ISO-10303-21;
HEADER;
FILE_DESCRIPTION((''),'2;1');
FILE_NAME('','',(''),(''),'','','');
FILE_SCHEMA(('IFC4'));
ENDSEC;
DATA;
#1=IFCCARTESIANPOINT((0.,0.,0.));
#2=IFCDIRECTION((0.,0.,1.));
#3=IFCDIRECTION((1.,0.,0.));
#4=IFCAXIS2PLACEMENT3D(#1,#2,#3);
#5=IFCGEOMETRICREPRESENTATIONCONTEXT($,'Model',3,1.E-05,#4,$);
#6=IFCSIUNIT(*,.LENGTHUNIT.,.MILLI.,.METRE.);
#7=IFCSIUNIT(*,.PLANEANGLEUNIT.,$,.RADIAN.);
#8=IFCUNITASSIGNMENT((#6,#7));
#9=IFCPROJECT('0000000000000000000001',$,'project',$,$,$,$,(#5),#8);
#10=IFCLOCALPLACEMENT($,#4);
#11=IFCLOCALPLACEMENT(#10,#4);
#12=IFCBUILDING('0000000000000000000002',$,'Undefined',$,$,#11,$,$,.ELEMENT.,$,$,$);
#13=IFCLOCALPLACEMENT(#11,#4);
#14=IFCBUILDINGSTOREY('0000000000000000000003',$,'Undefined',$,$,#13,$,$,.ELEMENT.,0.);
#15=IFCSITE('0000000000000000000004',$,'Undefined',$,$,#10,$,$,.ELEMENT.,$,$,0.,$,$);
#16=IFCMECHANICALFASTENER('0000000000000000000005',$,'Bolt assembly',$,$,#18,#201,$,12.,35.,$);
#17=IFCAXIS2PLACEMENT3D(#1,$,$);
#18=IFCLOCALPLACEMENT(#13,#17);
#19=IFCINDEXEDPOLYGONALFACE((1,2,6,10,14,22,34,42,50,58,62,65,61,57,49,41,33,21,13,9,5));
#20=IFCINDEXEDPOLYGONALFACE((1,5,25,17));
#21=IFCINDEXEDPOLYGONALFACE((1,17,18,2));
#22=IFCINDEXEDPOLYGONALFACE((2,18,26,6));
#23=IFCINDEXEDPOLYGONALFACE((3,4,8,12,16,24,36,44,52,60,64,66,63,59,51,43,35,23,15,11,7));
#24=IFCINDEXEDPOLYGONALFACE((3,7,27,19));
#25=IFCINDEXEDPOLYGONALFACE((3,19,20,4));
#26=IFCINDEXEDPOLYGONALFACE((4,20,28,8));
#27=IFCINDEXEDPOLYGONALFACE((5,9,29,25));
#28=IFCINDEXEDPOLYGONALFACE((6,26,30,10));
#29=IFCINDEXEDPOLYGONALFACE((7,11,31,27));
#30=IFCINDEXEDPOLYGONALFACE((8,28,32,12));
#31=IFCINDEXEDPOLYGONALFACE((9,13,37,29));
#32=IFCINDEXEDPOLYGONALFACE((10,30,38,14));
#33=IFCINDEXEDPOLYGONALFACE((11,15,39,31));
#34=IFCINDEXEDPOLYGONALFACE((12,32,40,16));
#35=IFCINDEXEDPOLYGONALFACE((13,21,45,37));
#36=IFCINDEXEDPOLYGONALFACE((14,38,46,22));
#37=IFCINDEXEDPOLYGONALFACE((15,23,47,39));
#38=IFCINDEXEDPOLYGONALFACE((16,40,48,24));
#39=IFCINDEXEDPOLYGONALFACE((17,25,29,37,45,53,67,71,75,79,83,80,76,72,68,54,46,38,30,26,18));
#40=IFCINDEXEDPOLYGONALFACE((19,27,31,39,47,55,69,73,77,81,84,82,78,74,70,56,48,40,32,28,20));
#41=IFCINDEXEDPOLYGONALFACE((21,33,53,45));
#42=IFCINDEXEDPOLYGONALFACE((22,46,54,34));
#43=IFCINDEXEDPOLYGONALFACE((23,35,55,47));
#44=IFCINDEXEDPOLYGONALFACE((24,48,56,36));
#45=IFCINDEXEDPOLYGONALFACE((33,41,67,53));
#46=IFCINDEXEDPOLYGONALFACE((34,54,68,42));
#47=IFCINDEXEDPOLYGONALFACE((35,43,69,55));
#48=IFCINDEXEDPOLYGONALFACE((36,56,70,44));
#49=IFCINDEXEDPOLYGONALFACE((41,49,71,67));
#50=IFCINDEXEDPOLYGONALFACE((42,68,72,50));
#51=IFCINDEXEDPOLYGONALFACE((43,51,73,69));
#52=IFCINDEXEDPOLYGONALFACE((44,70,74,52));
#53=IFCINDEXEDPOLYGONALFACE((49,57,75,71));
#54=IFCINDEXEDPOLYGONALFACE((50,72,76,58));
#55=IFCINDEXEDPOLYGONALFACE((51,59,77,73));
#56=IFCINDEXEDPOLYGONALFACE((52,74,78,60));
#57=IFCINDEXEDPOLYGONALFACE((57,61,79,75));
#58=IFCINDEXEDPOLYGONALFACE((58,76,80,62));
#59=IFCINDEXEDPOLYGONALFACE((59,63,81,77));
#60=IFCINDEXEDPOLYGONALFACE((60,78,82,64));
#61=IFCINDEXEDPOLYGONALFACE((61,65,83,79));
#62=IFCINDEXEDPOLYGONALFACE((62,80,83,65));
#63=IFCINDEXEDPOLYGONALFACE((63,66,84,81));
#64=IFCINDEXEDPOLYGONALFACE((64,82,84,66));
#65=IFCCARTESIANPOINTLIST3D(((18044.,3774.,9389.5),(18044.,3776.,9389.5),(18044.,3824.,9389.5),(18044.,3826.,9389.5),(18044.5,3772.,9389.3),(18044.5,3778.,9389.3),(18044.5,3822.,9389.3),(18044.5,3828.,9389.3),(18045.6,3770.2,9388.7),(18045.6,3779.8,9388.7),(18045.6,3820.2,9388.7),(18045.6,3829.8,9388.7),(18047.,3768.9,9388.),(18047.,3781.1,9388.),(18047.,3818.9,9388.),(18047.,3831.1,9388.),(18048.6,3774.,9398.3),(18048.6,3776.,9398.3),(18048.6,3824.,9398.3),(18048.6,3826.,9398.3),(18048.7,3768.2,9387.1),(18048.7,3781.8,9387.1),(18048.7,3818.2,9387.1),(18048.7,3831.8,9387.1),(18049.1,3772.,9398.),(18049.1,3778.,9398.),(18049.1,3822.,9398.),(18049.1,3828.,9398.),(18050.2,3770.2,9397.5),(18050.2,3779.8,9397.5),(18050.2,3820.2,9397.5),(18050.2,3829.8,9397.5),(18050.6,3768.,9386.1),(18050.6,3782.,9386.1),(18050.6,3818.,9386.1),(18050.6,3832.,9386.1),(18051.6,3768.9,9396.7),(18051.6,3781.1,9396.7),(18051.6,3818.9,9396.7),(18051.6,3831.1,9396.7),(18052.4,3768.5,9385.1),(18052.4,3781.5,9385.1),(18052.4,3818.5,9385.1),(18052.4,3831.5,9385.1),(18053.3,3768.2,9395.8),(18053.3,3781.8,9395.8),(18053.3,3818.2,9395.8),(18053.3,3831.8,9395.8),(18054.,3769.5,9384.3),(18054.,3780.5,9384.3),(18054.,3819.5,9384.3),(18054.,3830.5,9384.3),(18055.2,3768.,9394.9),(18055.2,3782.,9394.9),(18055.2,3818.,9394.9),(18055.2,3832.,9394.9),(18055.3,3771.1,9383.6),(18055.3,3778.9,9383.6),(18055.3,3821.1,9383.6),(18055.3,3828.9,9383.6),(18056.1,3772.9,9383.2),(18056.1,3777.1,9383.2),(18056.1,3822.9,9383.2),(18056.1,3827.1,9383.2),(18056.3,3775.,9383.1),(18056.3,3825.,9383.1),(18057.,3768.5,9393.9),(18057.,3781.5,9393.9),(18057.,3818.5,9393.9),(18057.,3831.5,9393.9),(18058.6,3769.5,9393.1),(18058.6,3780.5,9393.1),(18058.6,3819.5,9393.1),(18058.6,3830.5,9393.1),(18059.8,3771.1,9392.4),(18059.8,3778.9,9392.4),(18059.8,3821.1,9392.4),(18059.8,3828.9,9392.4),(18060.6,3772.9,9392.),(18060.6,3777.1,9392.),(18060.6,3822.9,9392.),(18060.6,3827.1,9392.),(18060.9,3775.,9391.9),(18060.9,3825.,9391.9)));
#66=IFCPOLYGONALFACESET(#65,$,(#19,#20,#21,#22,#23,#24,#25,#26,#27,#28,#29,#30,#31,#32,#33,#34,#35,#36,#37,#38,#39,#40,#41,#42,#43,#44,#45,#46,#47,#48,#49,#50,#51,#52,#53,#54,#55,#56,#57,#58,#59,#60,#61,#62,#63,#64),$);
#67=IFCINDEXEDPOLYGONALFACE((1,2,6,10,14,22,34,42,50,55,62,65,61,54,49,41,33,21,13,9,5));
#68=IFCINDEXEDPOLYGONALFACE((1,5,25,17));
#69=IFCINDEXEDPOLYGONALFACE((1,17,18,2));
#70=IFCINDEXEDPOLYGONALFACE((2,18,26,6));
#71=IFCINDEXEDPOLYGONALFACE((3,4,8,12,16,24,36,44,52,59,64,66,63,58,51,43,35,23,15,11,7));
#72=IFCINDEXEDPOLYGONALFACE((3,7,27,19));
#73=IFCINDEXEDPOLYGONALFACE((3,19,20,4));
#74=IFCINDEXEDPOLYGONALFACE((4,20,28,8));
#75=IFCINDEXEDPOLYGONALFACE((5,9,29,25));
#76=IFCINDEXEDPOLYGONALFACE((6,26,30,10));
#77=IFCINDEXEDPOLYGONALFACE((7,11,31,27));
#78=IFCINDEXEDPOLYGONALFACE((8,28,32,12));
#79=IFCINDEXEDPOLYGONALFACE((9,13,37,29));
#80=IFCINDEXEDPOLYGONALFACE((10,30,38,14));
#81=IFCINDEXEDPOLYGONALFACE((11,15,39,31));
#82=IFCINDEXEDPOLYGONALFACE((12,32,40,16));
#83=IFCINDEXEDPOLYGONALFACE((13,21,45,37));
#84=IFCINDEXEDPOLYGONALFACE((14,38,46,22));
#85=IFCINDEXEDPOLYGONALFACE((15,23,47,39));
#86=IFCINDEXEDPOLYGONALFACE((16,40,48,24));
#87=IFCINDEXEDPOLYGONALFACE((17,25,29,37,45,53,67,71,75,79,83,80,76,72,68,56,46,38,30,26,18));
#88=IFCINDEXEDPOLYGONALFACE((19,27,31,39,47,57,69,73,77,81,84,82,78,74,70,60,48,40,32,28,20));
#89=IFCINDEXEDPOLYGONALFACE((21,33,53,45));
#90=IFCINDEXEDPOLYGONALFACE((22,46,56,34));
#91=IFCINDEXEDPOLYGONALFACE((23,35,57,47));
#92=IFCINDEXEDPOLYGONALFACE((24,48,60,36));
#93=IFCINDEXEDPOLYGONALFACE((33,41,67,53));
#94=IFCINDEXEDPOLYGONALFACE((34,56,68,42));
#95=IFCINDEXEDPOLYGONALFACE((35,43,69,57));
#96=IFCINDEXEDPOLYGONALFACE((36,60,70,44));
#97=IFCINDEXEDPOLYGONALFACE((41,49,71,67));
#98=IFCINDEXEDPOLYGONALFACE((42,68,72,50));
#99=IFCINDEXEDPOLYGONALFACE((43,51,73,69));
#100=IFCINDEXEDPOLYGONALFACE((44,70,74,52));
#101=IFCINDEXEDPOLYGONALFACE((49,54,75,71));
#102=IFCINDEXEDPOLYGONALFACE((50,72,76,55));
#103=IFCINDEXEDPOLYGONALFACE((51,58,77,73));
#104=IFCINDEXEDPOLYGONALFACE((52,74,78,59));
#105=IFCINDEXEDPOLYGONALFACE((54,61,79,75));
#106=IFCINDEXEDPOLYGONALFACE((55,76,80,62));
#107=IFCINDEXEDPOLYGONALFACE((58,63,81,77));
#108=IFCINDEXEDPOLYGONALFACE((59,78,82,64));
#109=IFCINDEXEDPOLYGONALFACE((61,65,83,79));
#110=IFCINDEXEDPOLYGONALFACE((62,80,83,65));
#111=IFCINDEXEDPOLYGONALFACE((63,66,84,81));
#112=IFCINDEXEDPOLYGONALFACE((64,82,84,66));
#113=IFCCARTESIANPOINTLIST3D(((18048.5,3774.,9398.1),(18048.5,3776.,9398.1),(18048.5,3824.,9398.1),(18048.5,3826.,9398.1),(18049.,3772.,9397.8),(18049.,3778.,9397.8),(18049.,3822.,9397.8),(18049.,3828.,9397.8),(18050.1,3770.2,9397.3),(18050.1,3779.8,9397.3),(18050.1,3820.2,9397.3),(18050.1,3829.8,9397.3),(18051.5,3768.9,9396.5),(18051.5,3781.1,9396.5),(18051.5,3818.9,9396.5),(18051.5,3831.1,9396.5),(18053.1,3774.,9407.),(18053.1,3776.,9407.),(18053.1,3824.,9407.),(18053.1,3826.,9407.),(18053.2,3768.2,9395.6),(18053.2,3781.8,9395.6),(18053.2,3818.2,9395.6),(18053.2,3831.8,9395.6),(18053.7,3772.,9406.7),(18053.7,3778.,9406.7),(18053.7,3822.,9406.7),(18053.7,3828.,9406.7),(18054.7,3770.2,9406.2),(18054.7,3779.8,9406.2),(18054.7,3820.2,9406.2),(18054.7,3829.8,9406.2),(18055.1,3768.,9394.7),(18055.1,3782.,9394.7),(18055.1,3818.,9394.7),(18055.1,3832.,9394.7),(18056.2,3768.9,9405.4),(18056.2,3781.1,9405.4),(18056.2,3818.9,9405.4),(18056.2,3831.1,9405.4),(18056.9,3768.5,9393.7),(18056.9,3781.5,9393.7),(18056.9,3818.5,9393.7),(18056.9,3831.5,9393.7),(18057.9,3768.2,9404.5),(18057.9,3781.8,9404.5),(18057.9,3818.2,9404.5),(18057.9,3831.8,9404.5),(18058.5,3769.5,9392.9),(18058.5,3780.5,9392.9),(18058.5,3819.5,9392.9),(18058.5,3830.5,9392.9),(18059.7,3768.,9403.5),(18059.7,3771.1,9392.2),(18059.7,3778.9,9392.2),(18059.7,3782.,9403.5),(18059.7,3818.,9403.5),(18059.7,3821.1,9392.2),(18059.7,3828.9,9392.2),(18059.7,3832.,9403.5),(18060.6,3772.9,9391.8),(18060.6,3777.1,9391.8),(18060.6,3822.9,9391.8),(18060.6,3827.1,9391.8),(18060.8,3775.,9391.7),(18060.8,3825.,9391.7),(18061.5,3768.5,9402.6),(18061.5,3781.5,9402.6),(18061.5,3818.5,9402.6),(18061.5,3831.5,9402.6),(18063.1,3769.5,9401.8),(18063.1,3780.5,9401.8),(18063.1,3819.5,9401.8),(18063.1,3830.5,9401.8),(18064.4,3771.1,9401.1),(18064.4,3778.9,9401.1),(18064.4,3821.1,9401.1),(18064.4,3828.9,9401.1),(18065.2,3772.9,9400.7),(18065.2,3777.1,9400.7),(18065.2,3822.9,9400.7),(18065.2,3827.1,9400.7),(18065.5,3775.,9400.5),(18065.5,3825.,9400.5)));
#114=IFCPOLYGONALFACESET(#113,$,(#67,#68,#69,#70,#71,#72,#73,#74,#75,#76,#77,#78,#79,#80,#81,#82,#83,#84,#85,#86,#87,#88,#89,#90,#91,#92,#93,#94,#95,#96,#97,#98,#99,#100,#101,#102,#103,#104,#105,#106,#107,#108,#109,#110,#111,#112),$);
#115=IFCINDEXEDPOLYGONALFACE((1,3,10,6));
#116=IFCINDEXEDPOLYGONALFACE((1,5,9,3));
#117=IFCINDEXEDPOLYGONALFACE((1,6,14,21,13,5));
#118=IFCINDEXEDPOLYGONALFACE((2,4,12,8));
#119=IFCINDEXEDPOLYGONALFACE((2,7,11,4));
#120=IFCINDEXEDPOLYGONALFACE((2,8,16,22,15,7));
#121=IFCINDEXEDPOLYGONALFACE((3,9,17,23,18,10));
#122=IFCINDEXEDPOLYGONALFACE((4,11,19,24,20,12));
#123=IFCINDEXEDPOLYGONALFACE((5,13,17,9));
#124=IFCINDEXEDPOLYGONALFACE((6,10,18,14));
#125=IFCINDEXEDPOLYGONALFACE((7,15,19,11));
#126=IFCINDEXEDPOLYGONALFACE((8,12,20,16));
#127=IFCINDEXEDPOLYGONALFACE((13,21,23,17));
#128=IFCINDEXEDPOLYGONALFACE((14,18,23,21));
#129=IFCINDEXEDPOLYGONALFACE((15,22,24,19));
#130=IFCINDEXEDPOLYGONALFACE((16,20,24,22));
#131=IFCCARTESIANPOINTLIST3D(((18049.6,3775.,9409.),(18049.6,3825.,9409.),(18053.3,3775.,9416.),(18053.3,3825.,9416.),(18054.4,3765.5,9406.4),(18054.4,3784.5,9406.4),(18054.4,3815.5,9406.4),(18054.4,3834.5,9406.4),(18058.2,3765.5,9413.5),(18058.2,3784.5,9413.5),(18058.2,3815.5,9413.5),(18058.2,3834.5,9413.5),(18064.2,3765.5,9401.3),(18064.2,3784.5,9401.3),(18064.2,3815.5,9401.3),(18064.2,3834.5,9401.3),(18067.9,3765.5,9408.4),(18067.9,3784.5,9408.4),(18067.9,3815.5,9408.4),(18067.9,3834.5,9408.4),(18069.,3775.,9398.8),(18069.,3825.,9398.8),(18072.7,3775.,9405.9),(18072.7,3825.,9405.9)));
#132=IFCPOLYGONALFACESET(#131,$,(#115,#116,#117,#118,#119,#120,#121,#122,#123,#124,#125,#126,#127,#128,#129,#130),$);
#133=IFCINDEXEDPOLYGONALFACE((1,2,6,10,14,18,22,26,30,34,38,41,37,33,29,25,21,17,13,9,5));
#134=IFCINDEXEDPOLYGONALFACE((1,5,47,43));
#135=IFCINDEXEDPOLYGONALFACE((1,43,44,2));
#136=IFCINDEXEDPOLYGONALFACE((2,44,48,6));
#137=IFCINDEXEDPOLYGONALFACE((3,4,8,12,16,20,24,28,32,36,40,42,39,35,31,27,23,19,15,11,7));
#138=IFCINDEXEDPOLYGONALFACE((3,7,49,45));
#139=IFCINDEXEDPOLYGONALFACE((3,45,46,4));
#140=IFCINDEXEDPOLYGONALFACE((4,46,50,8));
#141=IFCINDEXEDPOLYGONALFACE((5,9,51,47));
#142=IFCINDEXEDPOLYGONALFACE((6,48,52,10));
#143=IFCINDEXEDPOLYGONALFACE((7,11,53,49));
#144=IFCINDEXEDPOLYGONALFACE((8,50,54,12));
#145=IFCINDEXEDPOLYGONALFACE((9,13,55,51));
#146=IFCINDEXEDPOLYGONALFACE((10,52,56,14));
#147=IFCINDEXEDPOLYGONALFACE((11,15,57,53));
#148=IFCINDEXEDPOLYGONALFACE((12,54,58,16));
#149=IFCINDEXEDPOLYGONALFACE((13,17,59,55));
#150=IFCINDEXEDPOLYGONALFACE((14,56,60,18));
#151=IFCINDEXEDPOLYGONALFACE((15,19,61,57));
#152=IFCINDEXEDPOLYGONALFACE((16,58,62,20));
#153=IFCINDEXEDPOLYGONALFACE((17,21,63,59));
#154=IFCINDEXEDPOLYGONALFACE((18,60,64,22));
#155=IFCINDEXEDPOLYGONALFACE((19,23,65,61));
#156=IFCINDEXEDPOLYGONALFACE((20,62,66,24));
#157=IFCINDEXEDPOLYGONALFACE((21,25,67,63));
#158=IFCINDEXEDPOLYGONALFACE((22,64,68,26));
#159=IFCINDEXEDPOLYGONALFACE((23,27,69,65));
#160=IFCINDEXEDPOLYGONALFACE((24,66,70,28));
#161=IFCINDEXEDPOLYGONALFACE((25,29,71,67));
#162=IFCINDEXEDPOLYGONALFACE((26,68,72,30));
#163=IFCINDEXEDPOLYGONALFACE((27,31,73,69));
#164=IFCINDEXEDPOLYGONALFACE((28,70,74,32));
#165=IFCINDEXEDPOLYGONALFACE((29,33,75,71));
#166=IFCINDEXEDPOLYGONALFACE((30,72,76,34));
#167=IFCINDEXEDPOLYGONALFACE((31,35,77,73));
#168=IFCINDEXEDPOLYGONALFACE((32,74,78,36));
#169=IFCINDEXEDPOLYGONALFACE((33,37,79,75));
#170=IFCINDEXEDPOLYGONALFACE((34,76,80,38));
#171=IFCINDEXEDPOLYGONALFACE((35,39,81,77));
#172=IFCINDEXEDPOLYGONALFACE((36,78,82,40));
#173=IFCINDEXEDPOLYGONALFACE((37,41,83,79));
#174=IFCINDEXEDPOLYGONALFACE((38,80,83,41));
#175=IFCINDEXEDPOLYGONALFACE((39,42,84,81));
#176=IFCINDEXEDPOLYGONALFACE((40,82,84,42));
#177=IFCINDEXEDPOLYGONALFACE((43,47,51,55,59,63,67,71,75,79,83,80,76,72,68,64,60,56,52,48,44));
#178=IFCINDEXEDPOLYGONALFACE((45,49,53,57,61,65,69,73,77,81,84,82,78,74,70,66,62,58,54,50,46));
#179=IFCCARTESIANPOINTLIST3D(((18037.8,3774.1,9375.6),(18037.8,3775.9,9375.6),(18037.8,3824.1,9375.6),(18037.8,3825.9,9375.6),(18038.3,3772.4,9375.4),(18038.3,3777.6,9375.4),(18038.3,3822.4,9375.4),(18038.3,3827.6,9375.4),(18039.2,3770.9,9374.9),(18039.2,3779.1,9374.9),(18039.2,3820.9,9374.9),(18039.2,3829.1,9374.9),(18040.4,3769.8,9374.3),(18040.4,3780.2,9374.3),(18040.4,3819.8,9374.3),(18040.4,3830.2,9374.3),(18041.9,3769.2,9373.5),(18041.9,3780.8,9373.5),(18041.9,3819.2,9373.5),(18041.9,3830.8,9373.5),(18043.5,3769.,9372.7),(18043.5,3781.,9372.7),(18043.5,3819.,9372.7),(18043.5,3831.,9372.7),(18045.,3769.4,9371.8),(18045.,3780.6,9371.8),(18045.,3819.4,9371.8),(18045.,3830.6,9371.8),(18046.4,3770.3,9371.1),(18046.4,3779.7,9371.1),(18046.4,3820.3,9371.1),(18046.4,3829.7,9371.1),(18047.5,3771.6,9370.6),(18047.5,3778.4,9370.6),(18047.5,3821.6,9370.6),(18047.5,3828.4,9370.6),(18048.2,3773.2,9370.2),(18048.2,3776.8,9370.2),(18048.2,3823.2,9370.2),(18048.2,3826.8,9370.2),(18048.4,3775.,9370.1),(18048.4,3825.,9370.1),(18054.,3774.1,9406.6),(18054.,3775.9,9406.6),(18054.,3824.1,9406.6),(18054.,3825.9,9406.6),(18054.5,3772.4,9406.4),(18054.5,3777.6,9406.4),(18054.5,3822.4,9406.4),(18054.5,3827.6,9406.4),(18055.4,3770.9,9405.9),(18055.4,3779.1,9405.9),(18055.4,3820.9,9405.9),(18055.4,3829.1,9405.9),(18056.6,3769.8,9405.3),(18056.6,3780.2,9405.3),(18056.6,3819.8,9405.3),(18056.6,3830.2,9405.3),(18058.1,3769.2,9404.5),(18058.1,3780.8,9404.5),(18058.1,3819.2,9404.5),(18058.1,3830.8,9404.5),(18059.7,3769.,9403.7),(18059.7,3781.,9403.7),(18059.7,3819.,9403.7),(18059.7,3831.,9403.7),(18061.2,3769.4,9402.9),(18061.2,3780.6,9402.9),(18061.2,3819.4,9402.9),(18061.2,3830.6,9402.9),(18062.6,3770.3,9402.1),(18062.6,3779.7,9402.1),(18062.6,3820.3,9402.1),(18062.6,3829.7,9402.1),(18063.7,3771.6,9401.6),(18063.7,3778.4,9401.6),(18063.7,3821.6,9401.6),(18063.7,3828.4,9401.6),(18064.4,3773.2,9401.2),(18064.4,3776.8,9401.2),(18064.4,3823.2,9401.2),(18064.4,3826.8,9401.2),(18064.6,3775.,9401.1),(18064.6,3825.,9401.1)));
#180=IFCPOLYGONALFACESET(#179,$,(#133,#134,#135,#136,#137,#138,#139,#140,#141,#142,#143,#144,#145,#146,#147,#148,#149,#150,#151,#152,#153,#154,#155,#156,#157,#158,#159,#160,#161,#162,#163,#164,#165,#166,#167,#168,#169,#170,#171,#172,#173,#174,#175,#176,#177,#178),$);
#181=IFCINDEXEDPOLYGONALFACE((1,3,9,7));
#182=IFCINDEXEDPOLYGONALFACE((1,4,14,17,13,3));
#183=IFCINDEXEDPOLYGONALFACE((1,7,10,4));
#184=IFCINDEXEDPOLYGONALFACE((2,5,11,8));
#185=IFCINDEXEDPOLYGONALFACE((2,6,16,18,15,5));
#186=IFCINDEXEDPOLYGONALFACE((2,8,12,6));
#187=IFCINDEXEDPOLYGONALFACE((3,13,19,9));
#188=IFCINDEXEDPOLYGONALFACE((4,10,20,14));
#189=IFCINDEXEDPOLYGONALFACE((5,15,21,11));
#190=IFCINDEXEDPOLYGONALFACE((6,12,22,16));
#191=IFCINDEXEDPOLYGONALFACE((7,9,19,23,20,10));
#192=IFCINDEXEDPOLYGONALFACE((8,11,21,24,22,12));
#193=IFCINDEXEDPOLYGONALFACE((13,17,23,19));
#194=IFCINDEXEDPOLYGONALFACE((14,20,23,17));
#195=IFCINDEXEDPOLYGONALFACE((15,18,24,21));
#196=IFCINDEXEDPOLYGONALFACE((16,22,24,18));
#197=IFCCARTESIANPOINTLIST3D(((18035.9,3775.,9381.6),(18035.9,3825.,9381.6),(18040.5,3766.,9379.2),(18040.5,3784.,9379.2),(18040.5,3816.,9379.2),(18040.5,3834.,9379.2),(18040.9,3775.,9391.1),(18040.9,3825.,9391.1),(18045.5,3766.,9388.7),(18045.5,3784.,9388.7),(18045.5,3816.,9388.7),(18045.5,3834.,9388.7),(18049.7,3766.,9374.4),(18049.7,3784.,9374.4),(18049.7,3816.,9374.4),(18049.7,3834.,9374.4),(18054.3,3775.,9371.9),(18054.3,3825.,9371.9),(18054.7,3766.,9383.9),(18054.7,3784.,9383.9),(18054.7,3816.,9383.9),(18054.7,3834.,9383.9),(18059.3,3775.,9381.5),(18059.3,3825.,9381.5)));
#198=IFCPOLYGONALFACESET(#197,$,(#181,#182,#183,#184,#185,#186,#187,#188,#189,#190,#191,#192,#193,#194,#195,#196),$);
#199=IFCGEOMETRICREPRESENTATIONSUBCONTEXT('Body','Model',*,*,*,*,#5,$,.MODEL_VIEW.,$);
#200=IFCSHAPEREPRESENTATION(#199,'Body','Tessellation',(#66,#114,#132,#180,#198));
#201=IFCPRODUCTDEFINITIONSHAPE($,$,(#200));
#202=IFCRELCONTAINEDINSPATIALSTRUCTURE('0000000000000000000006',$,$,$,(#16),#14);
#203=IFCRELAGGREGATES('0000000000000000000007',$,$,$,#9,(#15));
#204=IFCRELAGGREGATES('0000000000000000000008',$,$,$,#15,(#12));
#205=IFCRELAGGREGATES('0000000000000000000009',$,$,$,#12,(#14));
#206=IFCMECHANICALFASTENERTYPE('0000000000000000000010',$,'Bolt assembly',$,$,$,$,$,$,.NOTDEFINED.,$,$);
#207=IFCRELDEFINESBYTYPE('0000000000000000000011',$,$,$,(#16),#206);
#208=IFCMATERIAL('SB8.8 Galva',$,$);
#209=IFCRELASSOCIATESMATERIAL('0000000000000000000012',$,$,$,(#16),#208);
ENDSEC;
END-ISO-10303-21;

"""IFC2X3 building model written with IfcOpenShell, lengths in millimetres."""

from ifc_helpers import new_model, si_unit, frame, origin_with_axes, origin_2d_with_axis, place, context, subcontext, project, spatial, polyline, circle, outline, extrude, source, transform, mapped, material, type_object, element, save


model = new_model("IFC2X3")

# Units and contexts
model_context = context("Model", 3, precision=1e-05, world=origin_with_axes())
body_context = subcontext(model_context, "Body", "Model", "MODEL_VIEW")
ifc_project = project(units=[si_unit("LENGTHUNIT", "METRE", prefix="MILLI"), si_unit("PLANEANGLEUNIT", "RADIAN")], contexts=[model_context])

# Site, building, storey
site_placement = place(None, origin_with_axes())
site = spatial("IfcSite", under=ifc_project, at=site_placement, Name="Undefined", CompositionType="ELEMENT", RefElevation=0.0)
building_placement = place(site_placement, origin_with_axes())
building = spatial("IfcBuilding", under=site, at=building_placement, Name="Undefined", CompositionType="ELEMENT")
storey_placement = place(building_placement, origin_with_axes())
storey = spatial("IfcBuildingStorey", under=building, at=storey_placement, Name="Undefined", CompositionType="ELEMENT", Elevation=0.0)

# Mechanical fastener
mechanical_fastener_type = type_object("IfcMechanicalFastenerType", Name="Bolt assembly")
ifc_material_1 = material(Name="SB8.8 Galva")
shared_shape_1 = source(origin_with_axes(), body_context, "Body", "SweptSolid", [
    extrude(circle(Radius=7.0, at=origin_2d_with_axis()), frame((0.0, -0.1, 0.0), z_axis=(0.0, 1.0, 0.0), x_axis=(1.0, 0.0, 0.0)), (0.0, 0.0, 1.0), 9.9),
    extrude(circle(Radius=7.0, at=origin_2d_with_axis()), frame((0.0, -9.9, 0.0), z_axis=(0.0, 1.0, 0.0), x_axis=(1.0, 0.0, 0.0)), (0.0, 0.0, 1.0), 10.0),
    extrude(outline(polyline([(11.0, 0.0), (5.5, 9.5), (-5.5, 9.5), (-11.0, 0.0), (-5.5, -9.5), (5.5, -9.5), (11.0, 0.0)])), frame((0.0, -18.0, 0.0), z_axis=(0.0, 1.0, 0.0), x_axis=(1.0, 0.0, 0.0)), (0.0, 0.0, 1.0), 8.0),
    extrude(circle(Radius=6.0, at=origin_2d_with_axis()), frame((0.0, -10.0, 0.0), z_axis=(0.0, 1.0, 0.0), x_axis=(1.0, 0.0, 0.0)), (0.0, 0.0, 1.0), 35.0),
    extrude(outline(polyline([(10.4, 0.0), (5.2, 9.0), (-5.2, 9.0), (-10.4, 0.0), (-5.2, -9.0), (5.2, -9.0), (10.4, 0.0)])), frame((0.0, 9.8, 0.0), z_axis=(0.0, 1.0, 0.0), x_axis=(1.0, 0.0, 0.0)), (0.0, 0.0, 1.0), 10.8),
])
for number, where, z_axis, x_axis, name in (
    (1, (18054.7, 3800.0, 9395.0), (0.0, 1.0, 0.0), (0.886082, 0.0, -0.463529), "Bolt assembly"),
):
    element("IfcMechanicalFastener", number, at=place(storey_placement, frame(where, z_axis=z_axis, x_axis=x_axis)), inside=storey, type_object=mechanical_fastener_type, material=ifc_material_1, Name=name, NominalDiameter=12.0, NominalLength=35.0, context=body_context, shape_type="MappedRepresentation", body=[
        mapped(shared_shape_1, transform((0.0, 0.0, -25.0))),
        mapped(shared_shape_1, transform((0.0, 0.0, 25.0))),
    ])

save(model, "model.ifc")
